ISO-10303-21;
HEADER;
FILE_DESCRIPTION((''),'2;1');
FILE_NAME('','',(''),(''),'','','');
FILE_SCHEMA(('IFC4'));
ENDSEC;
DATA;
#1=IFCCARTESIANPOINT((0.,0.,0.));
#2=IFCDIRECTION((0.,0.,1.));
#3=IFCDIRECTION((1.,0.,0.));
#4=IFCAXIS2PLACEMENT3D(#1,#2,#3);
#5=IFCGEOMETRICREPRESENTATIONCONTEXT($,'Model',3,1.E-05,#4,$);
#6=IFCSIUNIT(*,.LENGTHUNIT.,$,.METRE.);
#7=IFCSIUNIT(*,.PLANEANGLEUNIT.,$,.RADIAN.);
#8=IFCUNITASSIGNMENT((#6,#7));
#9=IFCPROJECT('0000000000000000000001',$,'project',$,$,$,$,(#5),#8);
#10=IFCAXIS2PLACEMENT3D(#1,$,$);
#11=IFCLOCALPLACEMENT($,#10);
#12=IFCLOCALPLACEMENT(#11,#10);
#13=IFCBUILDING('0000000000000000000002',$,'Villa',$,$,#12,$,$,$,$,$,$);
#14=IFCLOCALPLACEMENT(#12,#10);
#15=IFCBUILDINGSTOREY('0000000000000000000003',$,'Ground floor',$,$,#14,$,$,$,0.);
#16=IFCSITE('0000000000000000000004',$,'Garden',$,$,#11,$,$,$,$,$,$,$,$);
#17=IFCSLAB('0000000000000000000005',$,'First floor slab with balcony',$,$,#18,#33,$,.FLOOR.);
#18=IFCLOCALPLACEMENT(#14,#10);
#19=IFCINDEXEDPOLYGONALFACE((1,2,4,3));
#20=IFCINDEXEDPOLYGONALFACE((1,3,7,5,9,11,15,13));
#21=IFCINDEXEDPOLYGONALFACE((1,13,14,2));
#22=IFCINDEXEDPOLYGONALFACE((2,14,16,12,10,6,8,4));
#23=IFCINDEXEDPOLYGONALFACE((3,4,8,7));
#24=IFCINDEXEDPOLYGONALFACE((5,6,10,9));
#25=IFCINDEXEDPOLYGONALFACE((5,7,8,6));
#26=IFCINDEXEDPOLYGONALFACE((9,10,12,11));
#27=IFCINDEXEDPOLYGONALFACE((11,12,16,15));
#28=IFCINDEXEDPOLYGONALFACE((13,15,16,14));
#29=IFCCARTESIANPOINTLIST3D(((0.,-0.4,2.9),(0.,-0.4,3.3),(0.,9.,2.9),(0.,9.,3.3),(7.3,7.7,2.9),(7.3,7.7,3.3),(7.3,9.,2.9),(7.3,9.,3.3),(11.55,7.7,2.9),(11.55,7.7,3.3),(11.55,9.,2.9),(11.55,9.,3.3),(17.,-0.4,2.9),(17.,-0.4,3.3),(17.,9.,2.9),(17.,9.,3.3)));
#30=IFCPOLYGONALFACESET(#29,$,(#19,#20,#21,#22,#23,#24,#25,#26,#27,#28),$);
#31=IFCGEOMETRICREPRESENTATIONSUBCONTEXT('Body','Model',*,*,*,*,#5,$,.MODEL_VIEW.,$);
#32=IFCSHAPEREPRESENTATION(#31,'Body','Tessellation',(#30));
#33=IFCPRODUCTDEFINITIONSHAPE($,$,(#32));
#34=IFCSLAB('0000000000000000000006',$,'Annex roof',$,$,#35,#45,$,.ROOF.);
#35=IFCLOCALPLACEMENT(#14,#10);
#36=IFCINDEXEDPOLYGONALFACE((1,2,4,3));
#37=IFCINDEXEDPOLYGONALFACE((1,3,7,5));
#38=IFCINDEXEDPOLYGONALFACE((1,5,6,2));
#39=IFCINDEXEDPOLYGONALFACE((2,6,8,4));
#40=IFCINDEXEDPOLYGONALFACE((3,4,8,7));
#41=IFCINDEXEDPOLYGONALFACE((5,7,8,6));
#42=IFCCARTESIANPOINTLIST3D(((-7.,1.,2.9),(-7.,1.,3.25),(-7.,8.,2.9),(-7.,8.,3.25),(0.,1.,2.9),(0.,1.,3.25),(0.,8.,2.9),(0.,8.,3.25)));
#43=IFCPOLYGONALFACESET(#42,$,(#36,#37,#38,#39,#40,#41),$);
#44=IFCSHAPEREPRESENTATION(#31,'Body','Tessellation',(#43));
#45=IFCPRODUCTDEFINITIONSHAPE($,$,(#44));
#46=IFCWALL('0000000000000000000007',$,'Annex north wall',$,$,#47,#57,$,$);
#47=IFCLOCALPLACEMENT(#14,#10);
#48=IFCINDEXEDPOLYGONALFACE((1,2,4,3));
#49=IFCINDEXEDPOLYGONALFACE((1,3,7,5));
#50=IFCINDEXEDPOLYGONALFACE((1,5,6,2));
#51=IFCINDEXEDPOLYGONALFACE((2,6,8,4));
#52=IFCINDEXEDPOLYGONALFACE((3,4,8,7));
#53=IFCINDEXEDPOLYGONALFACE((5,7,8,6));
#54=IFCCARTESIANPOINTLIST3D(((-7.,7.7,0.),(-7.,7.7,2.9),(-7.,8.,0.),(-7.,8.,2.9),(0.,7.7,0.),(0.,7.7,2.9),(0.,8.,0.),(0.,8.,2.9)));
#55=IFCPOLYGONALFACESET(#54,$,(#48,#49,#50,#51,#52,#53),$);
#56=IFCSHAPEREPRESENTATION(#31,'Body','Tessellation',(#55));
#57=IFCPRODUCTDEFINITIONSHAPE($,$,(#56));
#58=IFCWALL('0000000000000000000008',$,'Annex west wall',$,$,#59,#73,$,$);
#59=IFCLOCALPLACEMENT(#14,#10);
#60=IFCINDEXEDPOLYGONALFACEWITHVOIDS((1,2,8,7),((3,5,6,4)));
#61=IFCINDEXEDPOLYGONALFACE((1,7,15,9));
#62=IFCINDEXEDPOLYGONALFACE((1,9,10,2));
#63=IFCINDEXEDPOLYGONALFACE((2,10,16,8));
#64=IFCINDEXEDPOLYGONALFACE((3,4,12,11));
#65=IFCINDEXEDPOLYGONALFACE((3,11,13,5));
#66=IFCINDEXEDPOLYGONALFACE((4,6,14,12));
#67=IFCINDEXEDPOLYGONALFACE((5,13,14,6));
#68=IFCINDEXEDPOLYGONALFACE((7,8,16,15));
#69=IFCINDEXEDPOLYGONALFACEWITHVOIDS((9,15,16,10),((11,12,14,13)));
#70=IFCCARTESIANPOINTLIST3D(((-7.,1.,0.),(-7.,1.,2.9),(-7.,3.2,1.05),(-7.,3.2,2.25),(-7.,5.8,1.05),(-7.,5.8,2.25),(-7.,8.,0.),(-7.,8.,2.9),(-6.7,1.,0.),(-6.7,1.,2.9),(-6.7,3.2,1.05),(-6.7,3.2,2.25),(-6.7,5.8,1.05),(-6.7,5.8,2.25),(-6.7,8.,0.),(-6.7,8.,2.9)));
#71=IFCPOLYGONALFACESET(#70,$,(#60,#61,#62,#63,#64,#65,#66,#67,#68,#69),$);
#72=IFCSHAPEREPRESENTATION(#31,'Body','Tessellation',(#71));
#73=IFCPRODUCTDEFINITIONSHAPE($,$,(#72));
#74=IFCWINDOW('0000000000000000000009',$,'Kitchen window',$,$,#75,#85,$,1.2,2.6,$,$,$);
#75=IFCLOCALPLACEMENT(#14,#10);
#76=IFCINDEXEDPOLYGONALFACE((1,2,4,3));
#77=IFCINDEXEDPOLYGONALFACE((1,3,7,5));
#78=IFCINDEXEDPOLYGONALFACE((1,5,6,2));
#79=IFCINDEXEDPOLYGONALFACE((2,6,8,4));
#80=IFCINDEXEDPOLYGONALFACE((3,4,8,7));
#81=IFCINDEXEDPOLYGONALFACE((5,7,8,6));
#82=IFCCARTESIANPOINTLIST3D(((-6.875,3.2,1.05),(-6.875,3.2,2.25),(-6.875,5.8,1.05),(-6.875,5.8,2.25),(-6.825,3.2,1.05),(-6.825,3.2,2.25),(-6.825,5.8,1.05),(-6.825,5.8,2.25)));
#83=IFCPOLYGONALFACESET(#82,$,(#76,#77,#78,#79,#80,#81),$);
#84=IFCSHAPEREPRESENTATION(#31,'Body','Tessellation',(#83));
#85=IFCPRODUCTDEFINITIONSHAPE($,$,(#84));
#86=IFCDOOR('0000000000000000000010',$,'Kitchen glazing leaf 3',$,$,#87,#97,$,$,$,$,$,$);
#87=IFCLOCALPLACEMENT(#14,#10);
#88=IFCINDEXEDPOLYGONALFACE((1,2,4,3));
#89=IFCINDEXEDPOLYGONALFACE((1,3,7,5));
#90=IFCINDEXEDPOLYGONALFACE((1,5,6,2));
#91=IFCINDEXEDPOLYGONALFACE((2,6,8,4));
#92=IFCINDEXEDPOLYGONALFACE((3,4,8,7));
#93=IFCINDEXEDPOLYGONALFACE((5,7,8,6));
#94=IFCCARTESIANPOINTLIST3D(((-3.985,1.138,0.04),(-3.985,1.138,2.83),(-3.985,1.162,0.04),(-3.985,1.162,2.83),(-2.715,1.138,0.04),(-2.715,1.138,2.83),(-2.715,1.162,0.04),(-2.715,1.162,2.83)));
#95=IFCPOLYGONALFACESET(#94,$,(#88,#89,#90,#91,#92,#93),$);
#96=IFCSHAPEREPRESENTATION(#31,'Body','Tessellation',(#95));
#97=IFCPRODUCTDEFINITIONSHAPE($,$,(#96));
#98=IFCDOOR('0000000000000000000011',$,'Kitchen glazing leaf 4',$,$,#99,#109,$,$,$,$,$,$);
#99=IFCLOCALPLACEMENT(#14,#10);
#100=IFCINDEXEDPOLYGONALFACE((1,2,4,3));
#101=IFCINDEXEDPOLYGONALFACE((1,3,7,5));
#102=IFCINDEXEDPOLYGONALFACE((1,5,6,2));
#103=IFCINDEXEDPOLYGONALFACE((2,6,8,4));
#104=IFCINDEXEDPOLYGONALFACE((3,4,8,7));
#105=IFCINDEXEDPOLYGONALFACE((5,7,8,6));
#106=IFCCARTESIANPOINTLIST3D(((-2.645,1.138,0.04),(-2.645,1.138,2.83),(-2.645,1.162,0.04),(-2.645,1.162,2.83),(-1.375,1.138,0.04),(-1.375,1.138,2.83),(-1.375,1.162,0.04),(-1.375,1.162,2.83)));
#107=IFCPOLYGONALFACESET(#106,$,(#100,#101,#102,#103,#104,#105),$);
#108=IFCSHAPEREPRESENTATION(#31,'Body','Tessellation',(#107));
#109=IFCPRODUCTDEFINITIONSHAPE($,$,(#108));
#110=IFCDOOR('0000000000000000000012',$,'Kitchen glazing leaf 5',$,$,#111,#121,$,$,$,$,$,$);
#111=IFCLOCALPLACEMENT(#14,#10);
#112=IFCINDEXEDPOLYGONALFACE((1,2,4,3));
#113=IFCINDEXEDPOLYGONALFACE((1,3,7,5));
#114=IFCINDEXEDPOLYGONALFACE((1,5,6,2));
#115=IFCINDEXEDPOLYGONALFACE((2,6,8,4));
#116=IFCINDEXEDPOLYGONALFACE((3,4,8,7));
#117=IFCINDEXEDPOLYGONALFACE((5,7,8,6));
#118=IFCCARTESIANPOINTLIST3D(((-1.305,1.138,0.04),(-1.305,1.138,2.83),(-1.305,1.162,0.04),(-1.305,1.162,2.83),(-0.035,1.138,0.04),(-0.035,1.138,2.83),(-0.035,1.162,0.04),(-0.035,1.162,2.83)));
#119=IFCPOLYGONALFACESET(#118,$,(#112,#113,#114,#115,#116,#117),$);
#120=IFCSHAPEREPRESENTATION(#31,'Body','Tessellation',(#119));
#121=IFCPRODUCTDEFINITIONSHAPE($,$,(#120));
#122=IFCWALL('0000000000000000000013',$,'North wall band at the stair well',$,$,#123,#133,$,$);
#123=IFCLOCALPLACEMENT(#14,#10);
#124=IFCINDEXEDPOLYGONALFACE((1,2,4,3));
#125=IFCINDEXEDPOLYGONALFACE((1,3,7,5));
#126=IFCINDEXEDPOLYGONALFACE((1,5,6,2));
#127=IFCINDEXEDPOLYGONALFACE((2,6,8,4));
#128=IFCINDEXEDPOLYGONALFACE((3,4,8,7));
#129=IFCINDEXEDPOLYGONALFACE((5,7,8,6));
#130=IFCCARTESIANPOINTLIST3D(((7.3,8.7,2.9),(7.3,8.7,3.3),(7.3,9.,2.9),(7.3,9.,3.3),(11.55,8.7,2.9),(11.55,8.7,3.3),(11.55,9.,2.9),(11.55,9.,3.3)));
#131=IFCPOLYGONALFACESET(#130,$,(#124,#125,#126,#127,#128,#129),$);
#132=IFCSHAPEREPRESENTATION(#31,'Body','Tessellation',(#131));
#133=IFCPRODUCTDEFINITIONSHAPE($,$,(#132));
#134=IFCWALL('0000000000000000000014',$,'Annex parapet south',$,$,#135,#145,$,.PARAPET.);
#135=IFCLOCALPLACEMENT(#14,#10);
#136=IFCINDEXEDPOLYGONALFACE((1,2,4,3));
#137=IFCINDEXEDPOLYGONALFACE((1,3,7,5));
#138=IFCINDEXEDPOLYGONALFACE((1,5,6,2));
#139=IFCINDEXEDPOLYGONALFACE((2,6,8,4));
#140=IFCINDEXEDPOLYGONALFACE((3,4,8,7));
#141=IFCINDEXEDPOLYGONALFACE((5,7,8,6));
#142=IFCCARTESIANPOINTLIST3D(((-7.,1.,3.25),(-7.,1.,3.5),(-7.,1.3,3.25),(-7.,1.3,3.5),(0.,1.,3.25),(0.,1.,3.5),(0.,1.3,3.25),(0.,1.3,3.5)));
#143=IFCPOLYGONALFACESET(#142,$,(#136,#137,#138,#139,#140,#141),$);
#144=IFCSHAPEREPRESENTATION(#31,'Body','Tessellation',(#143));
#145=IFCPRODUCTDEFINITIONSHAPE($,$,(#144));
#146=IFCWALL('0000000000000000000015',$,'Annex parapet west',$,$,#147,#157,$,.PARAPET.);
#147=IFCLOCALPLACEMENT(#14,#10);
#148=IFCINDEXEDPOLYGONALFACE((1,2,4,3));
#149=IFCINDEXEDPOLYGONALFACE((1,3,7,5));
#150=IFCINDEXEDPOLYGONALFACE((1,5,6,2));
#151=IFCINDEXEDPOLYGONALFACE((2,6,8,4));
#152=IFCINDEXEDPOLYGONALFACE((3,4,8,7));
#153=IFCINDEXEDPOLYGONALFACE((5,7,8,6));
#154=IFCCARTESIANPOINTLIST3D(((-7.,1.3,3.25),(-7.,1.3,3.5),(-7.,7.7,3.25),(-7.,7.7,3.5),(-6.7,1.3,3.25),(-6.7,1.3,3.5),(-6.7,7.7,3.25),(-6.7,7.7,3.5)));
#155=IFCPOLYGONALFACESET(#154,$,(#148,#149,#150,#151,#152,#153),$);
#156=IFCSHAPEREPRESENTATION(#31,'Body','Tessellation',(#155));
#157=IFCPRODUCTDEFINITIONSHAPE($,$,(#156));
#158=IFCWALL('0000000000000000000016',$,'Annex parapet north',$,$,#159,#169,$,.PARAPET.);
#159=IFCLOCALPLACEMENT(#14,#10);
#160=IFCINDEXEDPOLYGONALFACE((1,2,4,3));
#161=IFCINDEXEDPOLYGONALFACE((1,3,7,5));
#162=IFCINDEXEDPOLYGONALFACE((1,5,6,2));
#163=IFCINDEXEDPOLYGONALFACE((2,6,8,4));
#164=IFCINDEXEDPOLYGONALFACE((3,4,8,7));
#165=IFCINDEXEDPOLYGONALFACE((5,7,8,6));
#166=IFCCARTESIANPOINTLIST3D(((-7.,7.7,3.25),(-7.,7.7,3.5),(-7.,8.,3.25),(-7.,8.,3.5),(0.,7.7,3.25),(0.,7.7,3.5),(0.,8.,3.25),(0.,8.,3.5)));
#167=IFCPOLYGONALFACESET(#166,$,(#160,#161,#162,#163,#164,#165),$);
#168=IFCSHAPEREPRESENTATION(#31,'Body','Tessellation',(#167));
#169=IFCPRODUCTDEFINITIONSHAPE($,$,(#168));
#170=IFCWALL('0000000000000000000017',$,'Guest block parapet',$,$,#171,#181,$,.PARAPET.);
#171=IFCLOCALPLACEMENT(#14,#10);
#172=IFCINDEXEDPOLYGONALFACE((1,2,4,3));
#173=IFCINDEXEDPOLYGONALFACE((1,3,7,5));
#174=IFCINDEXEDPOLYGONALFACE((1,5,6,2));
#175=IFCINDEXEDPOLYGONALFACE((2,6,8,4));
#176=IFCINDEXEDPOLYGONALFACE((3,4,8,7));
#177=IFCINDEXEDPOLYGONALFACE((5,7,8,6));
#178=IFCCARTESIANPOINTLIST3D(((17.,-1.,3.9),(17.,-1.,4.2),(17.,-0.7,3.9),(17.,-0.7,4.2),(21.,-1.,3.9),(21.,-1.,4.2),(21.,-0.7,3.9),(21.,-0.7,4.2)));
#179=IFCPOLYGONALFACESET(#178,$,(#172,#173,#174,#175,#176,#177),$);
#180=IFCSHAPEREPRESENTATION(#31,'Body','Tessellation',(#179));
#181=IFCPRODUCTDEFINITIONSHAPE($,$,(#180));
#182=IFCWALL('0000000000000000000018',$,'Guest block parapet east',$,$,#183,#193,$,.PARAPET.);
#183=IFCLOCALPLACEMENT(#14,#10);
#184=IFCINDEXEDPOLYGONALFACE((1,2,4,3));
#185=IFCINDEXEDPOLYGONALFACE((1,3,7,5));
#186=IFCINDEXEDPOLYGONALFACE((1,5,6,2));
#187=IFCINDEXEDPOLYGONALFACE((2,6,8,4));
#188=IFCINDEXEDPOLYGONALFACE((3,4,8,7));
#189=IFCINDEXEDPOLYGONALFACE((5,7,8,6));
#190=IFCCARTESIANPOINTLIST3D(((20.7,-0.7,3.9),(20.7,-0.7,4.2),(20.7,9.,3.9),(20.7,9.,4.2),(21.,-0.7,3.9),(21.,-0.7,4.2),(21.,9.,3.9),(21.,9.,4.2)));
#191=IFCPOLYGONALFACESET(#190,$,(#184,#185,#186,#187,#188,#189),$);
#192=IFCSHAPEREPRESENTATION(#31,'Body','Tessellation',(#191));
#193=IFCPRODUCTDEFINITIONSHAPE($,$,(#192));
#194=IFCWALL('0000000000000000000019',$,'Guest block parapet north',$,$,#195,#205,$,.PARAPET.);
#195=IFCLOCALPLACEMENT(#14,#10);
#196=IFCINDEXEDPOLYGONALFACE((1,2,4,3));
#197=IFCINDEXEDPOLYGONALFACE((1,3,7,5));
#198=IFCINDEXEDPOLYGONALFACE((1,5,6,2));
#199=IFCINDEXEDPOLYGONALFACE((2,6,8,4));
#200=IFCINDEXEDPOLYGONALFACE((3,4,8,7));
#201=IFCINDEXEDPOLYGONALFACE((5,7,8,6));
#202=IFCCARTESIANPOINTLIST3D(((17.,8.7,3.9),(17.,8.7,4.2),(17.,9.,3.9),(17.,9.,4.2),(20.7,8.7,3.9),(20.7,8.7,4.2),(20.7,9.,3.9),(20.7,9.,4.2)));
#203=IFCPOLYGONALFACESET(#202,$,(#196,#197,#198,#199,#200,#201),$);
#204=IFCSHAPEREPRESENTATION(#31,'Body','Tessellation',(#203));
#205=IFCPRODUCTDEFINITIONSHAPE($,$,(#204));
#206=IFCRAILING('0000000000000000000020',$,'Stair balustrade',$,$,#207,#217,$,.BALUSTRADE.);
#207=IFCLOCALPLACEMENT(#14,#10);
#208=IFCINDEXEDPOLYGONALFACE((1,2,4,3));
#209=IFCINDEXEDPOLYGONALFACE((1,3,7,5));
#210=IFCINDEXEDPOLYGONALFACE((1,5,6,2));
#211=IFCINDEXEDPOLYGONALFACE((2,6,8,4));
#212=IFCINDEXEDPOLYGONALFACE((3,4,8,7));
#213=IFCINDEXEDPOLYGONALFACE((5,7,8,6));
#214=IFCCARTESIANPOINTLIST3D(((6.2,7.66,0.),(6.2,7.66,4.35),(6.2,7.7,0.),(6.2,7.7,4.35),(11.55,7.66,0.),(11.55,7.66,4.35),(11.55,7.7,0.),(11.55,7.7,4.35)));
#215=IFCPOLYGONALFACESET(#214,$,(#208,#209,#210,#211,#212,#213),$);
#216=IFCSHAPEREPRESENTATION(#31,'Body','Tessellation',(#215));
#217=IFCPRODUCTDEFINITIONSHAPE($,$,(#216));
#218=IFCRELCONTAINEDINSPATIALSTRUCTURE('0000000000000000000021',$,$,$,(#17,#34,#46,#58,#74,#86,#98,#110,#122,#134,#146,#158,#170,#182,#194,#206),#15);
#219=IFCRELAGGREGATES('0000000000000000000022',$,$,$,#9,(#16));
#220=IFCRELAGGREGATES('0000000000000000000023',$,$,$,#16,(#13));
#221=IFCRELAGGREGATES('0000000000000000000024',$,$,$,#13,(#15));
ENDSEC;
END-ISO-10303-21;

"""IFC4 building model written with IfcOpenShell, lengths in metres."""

from ifc_helpers import new_model, si_unit, frame, frame_2d, origin, origin_with_axes, place, context, subcontext, project, spatial, polyline, rectangle, outline, extrude, element, fill, save


model = new_model("IFC4")

# Units and contexts
model_context = context("Model", 3, precision=1e-05, world=origin_with_axes())
body_context = subcontext(model_context, "Body", "Model", "MODEL_VIEW")
ifc_project = project(units=[si_unit("LENGTHUNIT", "METRE"), si_unit("PLANEANGLEUNIT", "RADIAN")], contexts=[model_context])

# Site, building, storey
site_placement = place(None, origin())
site = spatial("IfcSite", under=ifc_project, at=site_placement, Name="Garden")
building_placement = place(site_placement, origin())
building = spatial("IfcBuilding", under=site, at=building_placement, Name="Villa")
storey_placement = place(building_placement, origin())
storey = spatial("IfcBuildingStorey", under=building, at=storey_placement, Name="Ground floor", Elevation=0.0)

# Slabs
slab_1_placement = place(storey_placement, frame((0.0, 0.0, 2.9)))
element("IfcSlab", 1, at=slab_1_placement, inside=storey, Name="First floor slab with balcony", PredefinedType="FLOOR", context=body_context, shape_type="SweptSolid", body=[
    extrude(outline(polyline([(0.0, -0.4), (17.0, -0.4), (17.0, 9.0), (11.55, 9.0), (11.55, 7.7), (7.3, 7.7), (7.3, 9.0), (0.0, 9.0), (0.0, -0.4)])), origin(), (0.0, 0.0, 1.0), 0.4),
])
slab_2_placement = place(storey_placement, frame((0.0, 0.0, 2.9)))
element("IfcSlab", 2, at=slab_2_placement, inside=storey, Name="Annex roof", PredefinedType="ROOF", context=body_context, shape_type="SweptSolid", body=[
    extrude(outline(polyline([(-7.0, 1.0), (0.0, 1.0), (0.0, 8.0), (-7.0, 8.0), (-7.0, 1.0)])), origin(), (0.0, 0.0, 1.0), 0.35),
])

# Wall
wall_1_placement = place(storey_placement, frame((0.0, 7.85, 0.0), x_axis=(-1.0, 0.0, 0.0)))
element("IfcWall", 3, at=wall_1_placement, inside=storey, Name="Annex north wall", context=body_context, shape_type="SweptSolid", body=[
    extrude(rectangle(XDim=7.0, YDim=0.3, at=frame_2d((3.5, 0.0))), origin(), (0.0, 0.0, 1.0), 2.9),
])

# Wall, opening, window
wall_2_placement = place(storey_placement, frame((-6.85, 8.0, 0.0), x_axis=(0.0, -1.0, 0.0)))
wall_2 = element("IfcWall", 4, at=wall_2_placement, inside=storey, Name="Annex west wall", context=body_context, shape_type="SweptSolid", body=[
    extrude(rectangle(XDim=7.0, YDim=0.3, at=frame_2d((3.5, 0.0))), origin(), (0.0, 0.0, 1.0), 2.9),
])
opening_placement = place(wall_2_placement, frame((2.2, 0.0, 1.05)))
opening = element("IfcOpeningElement", 5, at=opening_placement, cuts=wall_2, context=body_context, shape_type="SweptSolid", body=[
    extrude(rectangle(XDim=2.6, YDim=0.4, at=frame_2d((1.3, 0.0))), origin(), (0.0, 0.0, 1.0), 1.2),
])
window_placement = place(opening_placement, origin())
window = element("IfcWindow", 6, at=window_placement, inside=storey, Name="Kitchen window", OverallHeight=1.2, OverallWidth=2.6, context=body_context, shape_type="SweptSolid", body=[
    extrude(rectangle(XDim=2.6, YDim=0.05, at=frame_2d((1.3, 0.0))), origin(), (0.0, 0.0, 1.0), 1.2),
])
fill(opening, window)

# Doors
door_1_placement = place(storey_placement, origin())
element("IfcDoor", 7, at=door_1_placement, inside=storey, Name="Kitchen glazing leaf 3", context=body_context, shape_type="SweptSolid", body=[
    extrude(rectangle(XDim=1.27, YDim=0.024, at=frame_2d((0.635, 0.012))), frame((-3.985, 1.138, 0.04)), (0.0, 0.0, 1.0), 2.79),
])
door_2_placement = place(storey_placement, origin())
element("IfcDoor", 8, at=door_2_placement, inside=storey, Name="Kitchen glazing leaf 4", context=body_context, shape_type="SweptSolid", body=[
    extrude(rectangle(XDim=1.27, YDim=0.024, at=frame_2d((0.635, 0.012))), frame((-2.645, 1.138, 0.04)), (0.0, 0.0, 1.0), 2.79),
])
door_3_placement = place(storey_placement, origin())
element("IfcDoor", 9, at=door_3_placement, inside=storey, Name="Kitchen glazing leaf 5", context=body_context, shape_type="SweptSolid", body=[
    extrude(rectangle(XDim=1.27, YDim=0.024, at=frame_2d((0.635, 0.012))), frame((-1.305, 1.138, 0.04)), (0.0, 0.0, 1.0), 2.79),
])

# Walls
wall_3_placement = place(storey_placement, origin())
element("IfcWall", 10, at=wall_3_placement, inside=storey, Name="North wall band at the stair well", context=body_context, shape_type="SweptSolid", body=[
    extrude(rectangle(XDim=4.25, YDim=0.3, at=frame_2d((2.125, 0.15))), frame((7.3, 8.7, 2.9)), (0.0, 0.0, 1.0), 0.4),
])
wall_4_placement = place(storey_placement, origin())
element("IfcWall", 11, at=wall_4_placement, inside=storey, Name="Annex parapet south", PredefinedType="PARAPET", context=body_context, shape_type="SweptSolid", body=[
    extrude(rectangle(XDim=7.0, YDim=0.3, at=frame_2d((3.5, 0.15))), frame((-7.0, 1.0, 3.25)), (0.0, 0.0, 1.0), 0.25),
])
wall_5_placement = place(storey_placement, origin())
element("IfcWall", 12, at=wall_5_placement, inside=storey, Name="Annex parapet west", PredefinedType="PARAPET", context=body_context, shape_type="SweptSolid", body=[
    extrude(rectangle(XDim=0.3, YDim=6.4, at=frame_2d((0.15, 3.2))), frame((-7.0, 1.3, 3.25)), (0.0, 0.0, 1.0), 0.25),
])
wall_6_placement = place(storey_placement, origin())
element("IfcWall", 13, at=wall_6_placement, inside=storey, Name="Annex parapet north", PredefinedType="PARAPET", context=body_context, shape_type="SweptSolid", body=[
    extrude(rectangle(XDim=7.0, YDim=0.3, at=frame_2d((3.5, 0.15))), frame((-7.0, 7.7, 3.25)), (0.0, 0.0, 1.0), 0.25),
])
wall_7_placement = place(storey_placement, origin())
element("IfcWall", 14, at=wall_7_placement, inside=storey, Name="Guest block parapet", PredefinedType="PARAPET", context=body_context, shape_type="SweptSolid", body=[
    extrude(rectangle(XDim=4.0, YDim=0.3, at=frame_2d((2.0, 0.15))), frame((17.0, -1.0, 3.9)), (0.0, 0.0, 1.0), 0.3),
])
wall_8_placement = place(storey_placement, origin())
element("IfcWall", 15, at=wall_8_placement, inside=storey, Name="Guest block parapet east", PredefinedType="PARAPET", context=body_context, shape_type="SweptSolid", body=[
    extrude(rectangle(XDim=0.3, YDim=9.7, at=frame_2d((0.15, 4.85))), frame((20.7, -0.7, 3.9)), (0.0, 0.0, 1.0), 0.3),
])
wall_9_placement = place(storey_placement, origin())
element("IfcWall", 16, at=wall_9_placement, inside=storey, Name="Guest block parapet north", PredefinedType="PARAPET", context=body_context, shape_type="SweptSolid", body=[
    extrude(rectangle(XDim=3.7, YDim=0.3, at=frame_2d((1.85, 0.15))), frame((17.0, 8.7, 3.9)), (0.0, 0.0, 1.0), 0.3),
])

# Railing
railing_placement = place(storey_placement, origin())
element("IfcRailing", 17, at=railing_placement, inside=storey, Name="Stair balustrade", PredefinedType="BALUSTRADE", context=body_context, shape_type="SweptSolid", body=[
    extrude(rectangle(XDim=5.35, YDim=0.04, at=frame_2d((2.675, 0.02))), frame((6.2, 7.66, 0.0)), (0.0, 0.0, 1.0), 4.35),
])

save(model, "model.ifc")
